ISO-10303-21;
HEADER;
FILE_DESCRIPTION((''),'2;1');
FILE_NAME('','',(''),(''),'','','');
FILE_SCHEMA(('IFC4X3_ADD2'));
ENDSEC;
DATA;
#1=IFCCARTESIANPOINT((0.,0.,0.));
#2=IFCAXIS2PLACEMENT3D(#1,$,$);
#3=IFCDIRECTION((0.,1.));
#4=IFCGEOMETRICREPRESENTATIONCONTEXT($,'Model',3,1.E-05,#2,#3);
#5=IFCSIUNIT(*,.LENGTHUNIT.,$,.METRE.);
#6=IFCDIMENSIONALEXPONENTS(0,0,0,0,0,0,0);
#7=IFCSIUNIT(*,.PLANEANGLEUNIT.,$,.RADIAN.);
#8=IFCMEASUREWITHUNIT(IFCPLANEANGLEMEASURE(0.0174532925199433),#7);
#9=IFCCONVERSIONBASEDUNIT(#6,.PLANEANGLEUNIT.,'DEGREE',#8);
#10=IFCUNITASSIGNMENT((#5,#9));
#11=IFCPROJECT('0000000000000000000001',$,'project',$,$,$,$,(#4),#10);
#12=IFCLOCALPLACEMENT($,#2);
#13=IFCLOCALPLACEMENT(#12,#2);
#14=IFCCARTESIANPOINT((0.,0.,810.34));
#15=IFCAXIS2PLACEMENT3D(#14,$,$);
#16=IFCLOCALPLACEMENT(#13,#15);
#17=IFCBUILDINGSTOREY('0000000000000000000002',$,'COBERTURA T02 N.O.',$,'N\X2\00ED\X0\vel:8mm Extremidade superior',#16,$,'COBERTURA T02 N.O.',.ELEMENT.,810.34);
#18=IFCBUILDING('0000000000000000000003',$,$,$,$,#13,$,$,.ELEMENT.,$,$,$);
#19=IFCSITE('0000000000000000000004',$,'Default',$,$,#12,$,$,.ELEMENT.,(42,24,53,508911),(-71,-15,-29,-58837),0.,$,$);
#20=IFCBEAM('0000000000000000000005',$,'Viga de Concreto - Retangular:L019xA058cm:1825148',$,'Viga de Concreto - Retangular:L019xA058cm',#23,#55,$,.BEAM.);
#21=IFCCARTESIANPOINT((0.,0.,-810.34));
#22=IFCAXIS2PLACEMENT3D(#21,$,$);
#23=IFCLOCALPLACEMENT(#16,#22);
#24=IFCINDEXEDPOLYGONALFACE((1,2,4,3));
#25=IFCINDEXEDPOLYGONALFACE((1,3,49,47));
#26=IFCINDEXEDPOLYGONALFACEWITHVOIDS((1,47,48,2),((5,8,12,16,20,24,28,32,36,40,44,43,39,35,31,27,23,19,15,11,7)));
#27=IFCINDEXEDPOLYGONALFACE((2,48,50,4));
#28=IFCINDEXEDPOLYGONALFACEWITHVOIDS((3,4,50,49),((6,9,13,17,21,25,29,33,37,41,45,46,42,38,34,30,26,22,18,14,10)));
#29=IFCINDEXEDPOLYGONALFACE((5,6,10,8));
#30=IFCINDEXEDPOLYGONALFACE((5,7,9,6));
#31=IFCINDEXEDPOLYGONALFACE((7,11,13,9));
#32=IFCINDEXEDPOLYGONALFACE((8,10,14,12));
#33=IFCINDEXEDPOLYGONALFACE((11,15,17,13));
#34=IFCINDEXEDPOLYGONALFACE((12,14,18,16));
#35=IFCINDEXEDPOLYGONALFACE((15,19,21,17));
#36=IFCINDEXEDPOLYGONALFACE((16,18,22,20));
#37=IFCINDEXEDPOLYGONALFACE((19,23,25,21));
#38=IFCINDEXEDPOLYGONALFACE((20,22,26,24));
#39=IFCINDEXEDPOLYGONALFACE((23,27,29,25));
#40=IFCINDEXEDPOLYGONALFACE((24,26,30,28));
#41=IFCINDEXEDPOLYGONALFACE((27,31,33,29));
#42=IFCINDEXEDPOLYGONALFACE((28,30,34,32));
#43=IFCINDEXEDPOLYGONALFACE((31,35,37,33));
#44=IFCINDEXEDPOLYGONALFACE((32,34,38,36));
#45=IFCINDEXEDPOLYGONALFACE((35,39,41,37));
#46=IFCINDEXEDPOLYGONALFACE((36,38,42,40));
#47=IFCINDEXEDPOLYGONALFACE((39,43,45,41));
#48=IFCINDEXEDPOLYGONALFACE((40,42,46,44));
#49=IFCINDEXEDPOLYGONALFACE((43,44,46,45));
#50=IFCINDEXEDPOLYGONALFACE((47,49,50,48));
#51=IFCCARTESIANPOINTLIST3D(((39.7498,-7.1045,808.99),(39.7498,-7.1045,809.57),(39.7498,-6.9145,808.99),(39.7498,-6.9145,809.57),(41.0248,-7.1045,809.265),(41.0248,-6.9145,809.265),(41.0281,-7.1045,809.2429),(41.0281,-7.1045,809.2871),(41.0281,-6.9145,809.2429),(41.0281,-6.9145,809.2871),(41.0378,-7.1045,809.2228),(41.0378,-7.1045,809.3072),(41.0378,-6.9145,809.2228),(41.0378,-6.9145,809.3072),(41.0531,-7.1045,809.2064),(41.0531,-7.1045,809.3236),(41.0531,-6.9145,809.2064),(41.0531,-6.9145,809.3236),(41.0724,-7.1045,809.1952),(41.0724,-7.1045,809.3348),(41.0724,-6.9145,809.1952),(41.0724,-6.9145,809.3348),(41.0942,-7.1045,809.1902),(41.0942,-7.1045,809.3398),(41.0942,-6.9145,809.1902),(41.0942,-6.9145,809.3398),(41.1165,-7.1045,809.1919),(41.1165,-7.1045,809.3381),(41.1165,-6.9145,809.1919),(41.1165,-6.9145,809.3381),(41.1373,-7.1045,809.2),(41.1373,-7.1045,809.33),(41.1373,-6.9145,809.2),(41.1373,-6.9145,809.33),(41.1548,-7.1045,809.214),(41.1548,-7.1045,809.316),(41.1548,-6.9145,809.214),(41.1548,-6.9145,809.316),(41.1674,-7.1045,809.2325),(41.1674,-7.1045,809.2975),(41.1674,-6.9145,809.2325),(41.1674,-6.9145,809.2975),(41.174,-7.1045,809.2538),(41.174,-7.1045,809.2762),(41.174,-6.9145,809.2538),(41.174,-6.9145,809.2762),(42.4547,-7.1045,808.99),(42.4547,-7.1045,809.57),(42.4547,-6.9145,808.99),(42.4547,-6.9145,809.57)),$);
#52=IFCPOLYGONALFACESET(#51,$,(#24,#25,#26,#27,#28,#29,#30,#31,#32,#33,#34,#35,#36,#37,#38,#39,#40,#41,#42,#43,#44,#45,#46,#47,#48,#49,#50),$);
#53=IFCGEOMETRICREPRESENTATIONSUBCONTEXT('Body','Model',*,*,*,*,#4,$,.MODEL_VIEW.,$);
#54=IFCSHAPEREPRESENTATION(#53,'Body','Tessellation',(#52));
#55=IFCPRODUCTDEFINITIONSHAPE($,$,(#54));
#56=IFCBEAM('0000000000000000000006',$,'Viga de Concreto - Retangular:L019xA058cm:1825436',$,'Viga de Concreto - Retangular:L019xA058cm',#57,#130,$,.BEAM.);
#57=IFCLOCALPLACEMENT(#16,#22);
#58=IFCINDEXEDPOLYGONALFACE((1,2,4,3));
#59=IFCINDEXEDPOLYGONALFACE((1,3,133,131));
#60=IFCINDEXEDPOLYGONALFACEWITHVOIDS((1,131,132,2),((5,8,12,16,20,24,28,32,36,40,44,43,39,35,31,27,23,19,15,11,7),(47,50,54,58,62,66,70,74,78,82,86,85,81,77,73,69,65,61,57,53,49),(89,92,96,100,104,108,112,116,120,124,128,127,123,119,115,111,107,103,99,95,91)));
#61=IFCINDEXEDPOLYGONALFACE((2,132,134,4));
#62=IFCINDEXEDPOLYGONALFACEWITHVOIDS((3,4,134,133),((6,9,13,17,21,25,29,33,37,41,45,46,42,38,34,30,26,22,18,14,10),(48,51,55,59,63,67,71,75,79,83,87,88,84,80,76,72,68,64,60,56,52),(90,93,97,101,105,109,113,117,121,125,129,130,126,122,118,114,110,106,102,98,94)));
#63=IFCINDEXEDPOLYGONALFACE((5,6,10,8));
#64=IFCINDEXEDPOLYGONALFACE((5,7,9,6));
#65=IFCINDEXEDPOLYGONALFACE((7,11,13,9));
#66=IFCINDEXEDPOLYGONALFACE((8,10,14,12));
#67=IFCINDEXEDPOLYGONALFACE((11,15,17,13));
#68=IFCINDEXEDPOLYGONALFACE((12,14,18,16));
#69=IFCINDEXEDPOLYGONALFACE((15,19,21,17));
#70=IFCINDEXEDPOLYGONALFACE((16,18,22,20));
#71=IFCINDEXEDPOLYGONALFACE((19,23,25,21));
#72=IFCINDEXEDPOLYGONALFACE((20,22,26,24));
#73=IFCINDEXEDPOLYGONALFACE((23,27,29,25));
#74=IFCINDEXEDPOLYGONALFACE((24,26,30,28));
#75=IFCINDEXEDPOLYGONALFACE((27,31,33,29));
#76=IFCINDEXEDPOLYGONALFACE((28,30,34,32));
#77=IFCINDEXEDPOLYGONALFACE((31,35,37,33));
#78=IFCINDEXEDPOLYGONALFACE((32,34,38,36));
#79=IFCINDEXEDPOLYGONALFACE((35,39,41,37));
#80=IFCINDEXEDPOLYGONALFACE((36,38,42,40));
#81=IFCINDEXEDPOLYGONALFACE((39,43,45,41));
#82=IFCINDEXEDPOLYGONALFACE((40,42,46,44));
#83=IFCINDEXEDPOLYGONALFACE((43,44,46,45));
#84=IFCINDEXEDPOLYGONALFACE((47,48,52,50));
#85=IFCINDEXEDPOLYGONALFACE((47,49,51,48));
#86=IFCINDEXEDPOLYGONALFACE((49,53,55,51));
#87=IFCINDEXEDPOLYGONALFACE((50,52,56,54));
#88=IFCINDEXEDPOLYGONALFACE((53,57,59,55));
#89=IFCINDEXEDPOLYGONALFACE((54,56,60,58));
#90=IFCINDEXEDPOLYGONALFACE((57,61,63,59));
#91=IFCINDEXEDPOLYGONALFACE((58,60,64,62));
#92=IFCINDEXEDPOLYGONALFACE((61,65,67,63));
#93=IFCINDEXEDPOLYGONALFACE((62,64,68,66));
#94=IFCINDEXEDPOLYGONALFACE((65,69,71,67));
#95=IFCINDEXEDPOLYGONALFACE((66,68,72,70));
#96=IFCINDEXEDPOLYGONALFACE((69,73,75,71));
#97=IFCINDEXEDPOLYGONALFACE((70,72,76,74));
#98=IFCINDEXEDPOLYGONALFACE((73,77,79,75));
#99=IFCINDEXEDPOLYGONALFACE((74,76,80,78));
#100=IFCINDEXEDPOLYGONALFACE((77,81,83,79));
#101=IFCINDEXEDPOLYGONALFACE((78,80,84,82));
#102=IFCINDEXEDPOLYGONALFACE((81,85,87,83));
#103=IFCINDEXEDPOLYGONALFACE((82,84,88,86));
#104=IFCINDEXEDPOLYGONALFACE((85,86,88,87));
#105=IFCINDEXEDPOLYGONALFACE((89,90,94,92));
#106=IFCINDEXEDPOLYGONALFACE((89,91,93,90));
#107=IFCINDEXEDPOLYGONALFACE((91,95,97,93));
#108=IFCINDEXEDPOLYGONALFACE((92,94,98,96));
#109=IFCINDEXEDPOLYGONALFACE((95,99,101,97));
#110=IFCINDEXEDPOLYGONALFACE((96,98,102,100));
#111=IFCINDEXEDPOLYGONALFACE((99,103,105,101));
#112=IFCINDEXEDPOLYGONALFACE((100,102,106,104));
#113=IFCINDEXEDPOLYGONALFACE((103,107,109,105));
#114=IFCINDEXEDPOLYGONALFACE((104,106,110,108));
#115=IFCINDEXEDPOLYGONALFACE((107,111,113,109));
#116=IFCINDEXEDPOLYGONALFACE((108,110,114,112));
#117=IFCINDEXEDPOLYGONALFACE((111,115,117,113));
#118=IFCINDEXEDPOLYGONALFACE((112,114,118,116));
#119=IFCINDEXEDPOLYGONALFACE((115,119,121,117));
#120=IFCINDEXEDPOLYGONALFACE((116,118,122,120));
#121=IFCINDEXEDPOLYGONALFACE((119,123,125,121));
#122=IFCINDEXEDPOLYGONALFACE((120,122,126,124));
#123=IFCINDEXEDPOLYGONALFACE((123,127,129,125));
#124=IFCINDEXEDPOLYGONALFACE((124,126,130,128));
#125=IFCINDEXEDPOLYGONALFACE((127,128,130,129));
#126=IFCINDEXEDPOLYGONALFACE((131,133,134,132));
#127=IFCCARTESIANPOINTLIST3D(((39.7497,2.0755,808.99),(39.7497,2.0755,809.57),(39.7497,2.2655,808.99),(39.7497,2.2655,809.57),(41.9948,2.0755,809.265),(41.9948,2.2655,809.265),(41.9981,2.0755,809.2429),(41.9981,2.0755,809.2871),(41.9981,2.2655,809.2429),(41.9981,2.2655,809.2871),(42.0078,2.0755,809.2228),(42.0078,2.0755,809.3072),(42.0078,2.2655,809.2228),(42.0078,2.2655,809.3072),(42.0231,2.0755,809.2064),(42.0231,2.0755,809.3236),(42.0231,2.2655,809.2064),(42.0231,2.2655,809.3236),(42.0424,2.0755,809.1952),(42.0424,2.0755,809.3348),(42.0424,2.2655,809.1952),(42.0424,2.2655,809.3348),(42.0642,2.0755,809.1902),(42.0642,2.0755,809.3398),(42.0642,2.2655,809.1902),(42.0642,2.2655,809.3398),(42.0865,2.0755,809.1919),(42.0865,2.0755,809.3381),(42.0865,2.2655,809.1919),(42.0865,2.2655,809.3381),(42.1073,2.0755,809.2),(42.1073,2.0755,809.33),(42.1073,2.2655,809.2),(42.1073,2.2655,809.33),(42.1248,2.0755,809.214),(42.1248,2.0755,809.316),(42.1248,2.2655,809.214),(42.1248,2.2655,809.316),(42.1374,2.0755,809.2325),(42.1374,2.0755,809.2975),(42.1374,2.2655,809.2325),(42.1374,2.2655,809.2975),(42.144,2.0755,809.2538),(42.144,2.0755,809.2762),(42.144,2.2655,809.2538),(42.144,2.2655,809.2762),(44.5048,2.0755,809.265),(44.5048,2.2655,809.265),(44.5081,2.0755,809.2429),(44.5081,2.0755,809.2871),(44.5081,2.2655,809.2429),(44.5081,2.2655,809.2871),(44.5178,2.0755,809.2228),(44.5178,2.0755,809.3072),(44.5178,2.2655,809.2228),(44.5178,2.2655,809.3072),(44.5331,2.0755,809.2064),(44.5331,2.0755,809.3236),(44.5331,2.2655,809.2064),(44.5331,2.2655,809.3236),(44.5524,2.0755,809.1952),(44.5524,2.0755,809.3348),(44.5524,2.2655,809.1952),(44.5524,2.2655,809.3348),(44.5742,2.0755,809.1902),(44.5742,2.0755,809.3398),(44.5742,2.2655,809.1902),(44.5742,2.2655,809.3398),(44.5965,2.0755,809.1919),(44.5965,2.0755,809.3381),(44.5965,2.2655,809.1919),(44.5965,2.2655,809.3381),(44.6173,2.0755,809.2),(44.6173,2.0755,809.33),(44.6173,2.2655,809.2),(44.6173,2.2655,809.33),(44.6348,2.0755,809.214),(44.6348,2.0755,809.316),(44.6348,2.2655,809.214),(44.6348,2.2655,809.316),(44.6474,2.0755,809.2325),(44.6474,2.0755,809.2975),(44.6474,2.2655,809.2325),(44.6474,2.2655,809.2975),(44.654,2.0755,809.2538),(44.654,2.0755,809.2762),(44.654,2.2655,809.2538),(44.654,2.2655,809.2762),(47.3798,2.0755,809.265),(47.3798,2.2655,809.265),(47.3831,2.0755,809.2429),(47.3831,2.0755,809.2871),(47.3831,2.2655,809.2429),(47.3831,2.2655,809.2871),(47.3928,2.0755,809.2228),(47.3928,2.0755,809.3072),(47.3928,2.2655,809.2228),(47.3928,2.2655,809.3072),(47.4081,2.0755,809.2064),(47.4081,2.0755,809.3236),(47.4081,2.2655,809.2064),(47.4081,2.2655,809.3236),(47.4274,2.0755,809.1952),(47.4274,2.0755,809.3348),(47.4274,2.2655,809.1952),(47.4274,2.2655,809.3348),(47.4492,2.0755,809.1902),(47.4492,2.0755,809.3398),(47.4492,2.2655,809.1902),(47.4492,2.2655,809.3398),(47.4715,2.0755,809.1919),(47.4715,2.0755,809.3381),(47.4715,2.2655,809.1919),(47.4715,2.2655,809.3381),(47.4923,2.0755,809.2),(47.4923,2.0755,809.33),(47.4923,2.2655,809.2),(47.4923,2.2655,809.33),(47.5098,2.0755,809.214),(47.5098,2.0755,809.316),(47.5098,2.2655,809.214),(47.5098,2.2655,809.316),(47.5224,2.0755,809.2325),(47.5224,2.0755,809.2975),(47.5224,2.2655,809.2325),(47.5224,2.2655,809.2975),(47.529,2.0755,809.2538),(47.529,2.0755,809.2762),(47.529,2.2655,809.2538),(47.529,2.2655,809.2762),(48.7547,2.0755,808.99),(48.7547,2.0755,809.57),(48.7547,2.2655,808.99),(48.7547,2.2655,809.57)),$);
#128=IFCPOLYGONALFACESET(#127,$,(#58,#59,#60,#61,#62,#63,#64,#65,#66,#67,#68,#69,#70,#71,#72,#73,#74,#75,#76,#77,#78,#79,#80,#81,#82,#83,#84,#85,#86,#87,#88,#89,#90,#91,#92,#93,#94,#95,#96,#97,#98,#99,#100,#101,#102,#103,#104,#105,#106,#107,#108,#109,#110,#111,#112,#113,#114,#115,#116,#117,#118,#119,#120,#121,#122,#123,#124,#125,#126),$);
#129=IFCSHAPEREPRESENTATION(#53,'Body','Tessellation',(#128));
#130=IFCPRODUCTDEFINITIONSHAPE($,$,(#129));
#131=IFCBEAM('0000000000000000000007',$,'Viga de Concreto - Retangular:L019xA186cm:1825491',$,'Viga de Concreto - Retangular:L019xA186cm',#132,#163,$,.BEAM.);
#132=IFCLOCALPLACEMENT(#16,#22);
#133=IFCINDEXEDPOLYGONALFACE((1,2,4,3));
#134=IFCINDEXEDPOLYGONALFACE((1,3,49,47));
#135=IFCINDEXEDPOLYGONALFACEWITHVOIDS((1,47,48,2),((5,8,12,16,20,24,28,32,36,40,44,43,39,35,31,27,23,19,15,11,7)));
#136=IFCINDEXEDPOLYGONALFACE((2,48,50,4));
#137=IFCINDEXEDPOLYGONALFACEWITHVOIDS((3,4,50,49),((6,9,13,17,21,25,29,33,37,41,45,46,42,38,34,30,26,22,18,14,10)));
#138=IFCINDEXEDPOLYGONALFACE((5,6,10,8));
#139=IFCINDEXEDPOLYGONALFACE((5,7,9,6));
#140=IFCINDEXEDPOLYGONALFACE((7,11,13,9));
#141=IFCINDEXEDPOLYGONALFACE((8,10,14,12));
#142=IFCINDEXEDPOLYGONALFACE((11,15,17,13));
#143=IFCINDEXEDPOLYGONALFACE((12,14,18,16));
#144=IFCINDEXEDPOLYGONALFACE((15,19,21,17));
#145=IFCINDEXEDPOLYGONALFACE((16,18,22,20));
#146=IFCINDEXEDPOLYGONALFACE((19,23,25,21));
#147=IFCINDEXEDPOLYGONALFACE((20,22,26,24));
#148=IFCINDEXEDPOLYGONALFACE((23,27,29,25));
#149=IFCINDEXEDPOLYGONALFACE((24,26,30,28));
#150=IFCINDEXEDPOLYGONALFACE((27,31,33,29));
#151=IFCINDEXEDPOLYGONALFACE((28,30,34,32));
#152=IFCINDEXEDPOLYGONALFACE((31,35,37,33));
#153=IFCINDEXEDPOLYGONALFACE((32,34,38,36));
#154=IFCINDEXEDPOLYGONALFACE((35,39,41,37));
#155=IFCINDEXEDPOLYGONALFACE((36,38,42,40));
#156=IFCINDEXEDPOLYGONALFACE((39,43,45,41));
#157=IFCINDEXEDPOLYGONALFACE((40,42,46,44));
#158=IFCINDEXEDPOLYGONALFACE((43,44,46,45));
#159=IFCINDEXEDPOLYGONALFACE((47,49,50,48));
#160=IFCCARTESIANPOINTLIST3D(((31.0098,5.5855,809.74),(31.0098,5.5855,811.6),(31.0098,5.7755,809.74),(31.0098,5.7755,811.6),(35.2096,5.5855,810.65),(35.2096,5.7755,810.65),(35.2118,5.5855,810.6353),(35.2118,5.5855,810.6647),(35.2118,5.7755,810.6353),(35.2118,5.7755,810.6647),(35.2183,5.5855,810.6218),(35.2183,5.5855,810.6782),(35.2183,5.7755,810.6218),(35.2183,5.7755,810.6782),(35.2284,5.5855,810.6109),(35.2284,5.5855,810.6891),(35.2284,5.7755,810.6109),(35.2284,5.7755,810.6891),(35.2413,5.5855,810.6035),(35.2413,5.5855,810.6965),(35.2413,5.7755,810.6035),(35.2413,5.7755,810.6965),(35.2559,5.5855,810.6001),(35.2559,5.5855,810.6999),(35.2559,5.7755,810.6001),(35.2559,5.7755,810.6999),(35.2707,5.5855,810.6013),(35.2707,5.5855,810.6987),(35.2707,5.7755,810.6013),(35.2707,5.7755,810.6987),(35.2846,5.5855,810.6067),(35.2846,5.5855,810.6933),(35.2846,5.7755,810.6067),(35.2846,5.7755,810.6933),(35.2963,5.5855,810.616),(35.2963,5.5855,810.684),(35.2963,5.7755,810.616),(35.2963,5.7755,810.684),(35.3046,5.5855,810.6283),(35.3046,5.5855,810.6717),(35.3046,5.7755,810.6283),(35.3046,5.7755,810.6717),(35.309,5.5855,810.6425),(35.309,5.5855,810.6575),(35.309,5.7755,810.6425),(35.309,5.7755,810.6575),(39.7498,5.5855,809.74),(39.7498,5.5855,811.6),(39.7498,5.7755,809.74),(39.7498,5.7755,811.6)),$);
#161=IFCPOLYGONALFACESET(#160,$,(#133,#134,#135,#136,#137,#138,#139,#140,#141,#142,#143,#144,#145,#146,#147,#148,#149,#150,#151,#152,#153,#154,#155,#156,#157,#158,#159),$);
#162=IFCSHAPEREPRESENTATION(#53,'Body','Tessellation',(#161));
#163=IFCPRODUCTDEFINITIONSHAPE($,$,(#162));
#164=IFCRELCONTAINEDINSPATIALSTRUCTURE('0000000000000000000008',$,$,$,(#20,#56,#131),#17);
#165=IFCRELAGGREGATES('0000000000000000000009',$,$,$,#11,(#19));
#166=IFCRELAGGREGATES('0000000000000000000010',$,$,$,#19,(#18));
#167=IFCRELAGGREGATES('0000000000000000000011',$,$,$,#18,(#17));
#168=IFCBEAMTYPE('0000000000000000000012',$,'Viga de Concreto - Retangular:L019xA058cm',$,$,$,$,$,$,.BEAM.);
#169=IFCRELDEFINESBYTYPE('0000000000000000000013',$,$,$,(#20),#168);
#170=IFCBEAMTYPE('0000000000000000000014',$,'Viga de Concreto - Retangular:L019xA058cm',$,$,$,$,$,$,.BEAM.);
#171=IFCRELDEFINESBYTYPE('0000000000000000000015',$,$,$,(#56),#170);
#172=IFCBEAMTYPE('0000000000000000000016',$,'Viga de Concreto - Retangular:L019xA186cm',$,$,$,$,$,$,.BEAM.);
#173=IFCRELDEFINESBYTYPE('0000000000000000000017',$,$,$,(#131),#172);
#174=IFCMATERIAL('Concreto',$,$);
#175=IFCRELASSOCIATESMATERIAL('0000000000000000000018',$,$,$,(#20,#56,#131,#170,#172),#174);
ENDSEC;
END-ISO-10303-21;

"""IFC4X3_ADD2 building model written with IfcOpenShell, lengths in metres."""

from ifc_helpers import new_model, entity, si_unit, converted_unit, direction, frame, frame_2d, origin, origin_2d_with_axis, place, context, subcontext, project, spatial, polyline, segment, composite_curve, rectangle, circle, outline, extrude, boolean, source, transform, mapped, material, material_profile, profile_set, type_object, type_shapes, element, save


model = new_model("IFC4X3_ADD2")

# Units and contexts
model_context = context("Model", 3, precision=1e-05, world=origin(), true_north=direction((0.0, 1.0)))
body_context = subcontext(model_context, "Body", "Model", "MODEL_VIEW")
ifc_project = project(units=[si_unit("LENGTHUNIT", "METRE"), converted_unit("PLANEANGLEUNIT", "DEGREE", entity("IfcPlaneAngleMeasure", 0.0174532925199433), si_unit("PLANEANGLEUNIT", "RADIAN"), dimensions=[0, 0, 0, 0, 0, 0, 0])], contexts=[model_context])

# Site, building, storey
site_placement = place(None, origin())
site = spatial("IfcSite", under=ifc_project, at=site_placement, Name="Default", CompositionType="ELEMENT", RefLatitude=(42, 24, 53, 508911), RefLongitude=(-71, -15, -29, -58837), RefElevation=0.0)
building_placement = place(site_placement, origin())
building = spatial("IfcBuilding", under=site, at=building_placement, CompositionType="ELEMENT")
storey_placement = place(building_placement, frame((0.0, 0.0, 810.34)))
storey = spatial("IfcBuildingStorey", under=building, at=storey_placement, Name="COBERTURA T02 N.O.", ObjectType="Nível:8mm Extremidade superior", LongName="COBERTURA T02 N.O.", CompositionType="ELEMENT", Elevation=810.34)

# Shared definitions
ifc_material = material(Name="Concreto")

# Beams
beam_type_1 = type_object("IfcBeamType", Name="Viga de Concreto - Retangular:L019xA058cm", PredefinedType="BEAM")
shared_shape_1 = source(origin(), body_context, "Body", "CSG", [
    boolean("DIFFERENCE", extrude(rectangle(XDim=0.58, YDim=0.19, at=frame_2d((0.0, 0.0), x_axis=(0.0, 1.0))), frame((39.7498, -7.0095, 809.28), z_axis=(1.0, 0.0, 0.0), x_axis=(0.0, 1.0, 0.0)), (0.0, 0.0, 1.0), 2.7049), extrude(circle(Radius=0.075, at=origin_2d_with_axis()), frame((41.0998, -6.9145, 809.265), z_axis=(0.0, -1.0, 0.0), x_axis=(-1.0, 0.0, 0.0)), (0.0, 0.0, 1.0), 0.19)),
])
type_shapes(beam_type_1, [shared_shape_1])
beam_1_placement = place(storey_placement, frame((0.0, 0.0, -810.34)))
element("IfcBeam", 1, at=beam_1_placement, inside=storey, type_object=beam_type_1, material=ifc_material, Name="Viga de Concreto - Retangular:L019xA058cm:1825148", ObjectType="Viga de Concreto - Retangular:L019xA058cm", PredefinedType="BEAM", context=body_context, shape_type="MappedRepresentation", body=[
    mapped(shared_shape_1, transform((0.0, 0.0, 0.0), scale=1.0)),
])
ifc_material_profile_1 = material_profile(ifc_material, outline(composite_curve([segment(polyline([(-0.095, 0.29, 0.0), (0.095, 0.29, 0.0)]), True, "CONTINUOUS"), segment(polyline([(0.095, 0.29, 0.0), (0.095, -0.29, 0.0)]), True, "CONTINUOUS"), segment(polyline([(0.095, -0.29, 0.0), (-0.095, -0.29, 0.0)]), True, "CONTINUOUS"), segment(polyline([(-0.095, -0.29, 0.0), (-0.095, 0.29, 0.0)]), True, "CONTINUOUS")], self_intersect=False), kind="CURVE"), Name="L019xA058cm")
ifc_material_profile_2 = material_profile(ifc_material, outline(composite_curve([segment(polyline([(1.4475, 0.095, 0.29), (1.4475, -0.095, 0.29)]), True, "CONTINUOUS"), segment(polyline([(1.4475, -0.095, 0.29), (1.4475, -0.095, -0.29)]), True, "CONTINUOUS"), segment(polyline([(1.4475, -0.095, -0.29), (1.4475, 0.095, -0.29)]), True, "CONTINUOUS"), segment(polyline([(1.4475, 0.095, -0.29), (1.4475, 0.095, 0.29)]), True, "CONTINUOUS")], self_intersect=False), kind="CURVE"), Name="L019xA058cm")
ifc_profile_set_1 = profile_set([ifc_material_profile_1, ifc_material_profile_2], Name="L019xA058cm")
beam_type_2 = type_object("IfcBeamType", Name="Viga de Concreto - Retangular:L019xA058cm", PredefinedType="BEAM", material=ifc_profile_set_1)
shared_shape_2 = source(origin(), body_context, "Body", "CSG", [
    boolean("DIFFERENCE", boolean("DIFFERENCE", boolean("DIFFERENCE", extrude(rectangle(XDim=0.58, YDim=0.19, at=frame_2d((0.0, 0.0), x_axis=(0.0, 1.0))), frame((39.7497, 2.1705, 809.28), z_axis=(1.0, 0.0, 0.0), x_axis=(0.0, 1.0, 0.0)), (0.0, 0.0, 1.0), 9.005), extrude(circle(Radius=0.075, at=origin_2d_with_axis()), frame((44.5798, 2.2655, 809.265), z_axis=(0.0, -1.0, 0.0), x_axis=(-1.0, 0.0, 0.0)), (0.0, 0.0, 1.0), 0.19)), extrude(circle(Radius=0.075, at=origin_2d_with_axis()), frame((42.0698, 2.0755, 809.265), z_axis=(0.0, 1.0, 0.0), x_axis=(-1.0, 0.0, 0.0)), (0.0, 0.0, 1.0), 0.19)), extrude(circle(Radius=0.075, at=origin_2d_with_axis()), frame((47.4548, 2.2655, 809.265), z_axis=(0.0, -1.0, 0.0), x_axis=(-1.0, 0.0, 0.0)), (0.0, 0.0, 1.0), 0.19)),
])
type_shapes(beam_type_2, [shared_shape_2])
beam_2_placement = place(storey_placement, frame((0.0, 0.0, -810.34)))
element("IfcBeam", 2, at=beam_2_placement, inside=storey, type_object=beam_type_2, material=ifc_material, Name="Viga de Concreto - Retangular:L019xA058cm:1825436", ObjectType="Viga de Concreto - Retangular:L019xA058cm", PredefinedType="BEAM", context=body_context, shape_type="MappedRepresentation", body=[
    mapped(shared_shape_2, transform((0.0, 0.0, 0.0), scale=1.0)),
])
ifc_material_profile_3 = material_profile(ifc_material, rectangle(XDim=1.86, YDim=0.19, at=frame_2d((0.0, 0.0), x_axis=(0.0, 1.0))), Name="L019xA186cm")
ifc_profile_set_2 = profile_set([ifc_material_profile_3], Name="L019xA186cm")
beam_type_3 = type_object("IfcBeamType", Name="Viga de Concreto - Retangular:L019xA186cm", PredefinedType="BEAM", material=ifc_profile_set_2)
shared_shape_3 = source(origin(), body_context, "Body", "CSG", [
    boolean("DIFFERENCE", extrude(rectangle(XDim=1.86, YDim=0.19, at=frame_2d((0.0, 0.0), x_axis=(0.0, 1.0))), frame((39.7498, 5.6805, 810.67), z_axis=(-1.0, 0.0, 0.0), x_axis=(0.0, -1.0, 0.0)), (0.0, 0.0, 1.0), 8.74), extrude(circle(Radius=0.05, at=origin_2d_with_axis()), frame((35.2596, 5.5855, 810.65), z_axis=(0.0, 1.0, 0.0), x_axis=(-1.0, 0.0, 0.0)), (0.0, 0.0, 1.0), 0.19)),
])
type_shapes(beam_type_3, [shared_shape_3])
beam_3_placement = place(storey_placement, frame((0.0, 0.0, -810.34)))
element("IfcBeam", 3, at=beam_3_placement, inside=storey, type_object=beam_type_3, material=ifc_material, Name="Viga de Concreto - Retangular:L019xA186cm:1825491", ObjectType="Viga de Concreto - Retangular:L019xA186cm", PredefinedType="BEAM", context=body_context, shape_type="MappedRepresentation", body=[
    mapped(shared_shape_3, transform((0.0, 0.0, 0.0), scale=1.0)),
])

save(model, "model.ifc")
